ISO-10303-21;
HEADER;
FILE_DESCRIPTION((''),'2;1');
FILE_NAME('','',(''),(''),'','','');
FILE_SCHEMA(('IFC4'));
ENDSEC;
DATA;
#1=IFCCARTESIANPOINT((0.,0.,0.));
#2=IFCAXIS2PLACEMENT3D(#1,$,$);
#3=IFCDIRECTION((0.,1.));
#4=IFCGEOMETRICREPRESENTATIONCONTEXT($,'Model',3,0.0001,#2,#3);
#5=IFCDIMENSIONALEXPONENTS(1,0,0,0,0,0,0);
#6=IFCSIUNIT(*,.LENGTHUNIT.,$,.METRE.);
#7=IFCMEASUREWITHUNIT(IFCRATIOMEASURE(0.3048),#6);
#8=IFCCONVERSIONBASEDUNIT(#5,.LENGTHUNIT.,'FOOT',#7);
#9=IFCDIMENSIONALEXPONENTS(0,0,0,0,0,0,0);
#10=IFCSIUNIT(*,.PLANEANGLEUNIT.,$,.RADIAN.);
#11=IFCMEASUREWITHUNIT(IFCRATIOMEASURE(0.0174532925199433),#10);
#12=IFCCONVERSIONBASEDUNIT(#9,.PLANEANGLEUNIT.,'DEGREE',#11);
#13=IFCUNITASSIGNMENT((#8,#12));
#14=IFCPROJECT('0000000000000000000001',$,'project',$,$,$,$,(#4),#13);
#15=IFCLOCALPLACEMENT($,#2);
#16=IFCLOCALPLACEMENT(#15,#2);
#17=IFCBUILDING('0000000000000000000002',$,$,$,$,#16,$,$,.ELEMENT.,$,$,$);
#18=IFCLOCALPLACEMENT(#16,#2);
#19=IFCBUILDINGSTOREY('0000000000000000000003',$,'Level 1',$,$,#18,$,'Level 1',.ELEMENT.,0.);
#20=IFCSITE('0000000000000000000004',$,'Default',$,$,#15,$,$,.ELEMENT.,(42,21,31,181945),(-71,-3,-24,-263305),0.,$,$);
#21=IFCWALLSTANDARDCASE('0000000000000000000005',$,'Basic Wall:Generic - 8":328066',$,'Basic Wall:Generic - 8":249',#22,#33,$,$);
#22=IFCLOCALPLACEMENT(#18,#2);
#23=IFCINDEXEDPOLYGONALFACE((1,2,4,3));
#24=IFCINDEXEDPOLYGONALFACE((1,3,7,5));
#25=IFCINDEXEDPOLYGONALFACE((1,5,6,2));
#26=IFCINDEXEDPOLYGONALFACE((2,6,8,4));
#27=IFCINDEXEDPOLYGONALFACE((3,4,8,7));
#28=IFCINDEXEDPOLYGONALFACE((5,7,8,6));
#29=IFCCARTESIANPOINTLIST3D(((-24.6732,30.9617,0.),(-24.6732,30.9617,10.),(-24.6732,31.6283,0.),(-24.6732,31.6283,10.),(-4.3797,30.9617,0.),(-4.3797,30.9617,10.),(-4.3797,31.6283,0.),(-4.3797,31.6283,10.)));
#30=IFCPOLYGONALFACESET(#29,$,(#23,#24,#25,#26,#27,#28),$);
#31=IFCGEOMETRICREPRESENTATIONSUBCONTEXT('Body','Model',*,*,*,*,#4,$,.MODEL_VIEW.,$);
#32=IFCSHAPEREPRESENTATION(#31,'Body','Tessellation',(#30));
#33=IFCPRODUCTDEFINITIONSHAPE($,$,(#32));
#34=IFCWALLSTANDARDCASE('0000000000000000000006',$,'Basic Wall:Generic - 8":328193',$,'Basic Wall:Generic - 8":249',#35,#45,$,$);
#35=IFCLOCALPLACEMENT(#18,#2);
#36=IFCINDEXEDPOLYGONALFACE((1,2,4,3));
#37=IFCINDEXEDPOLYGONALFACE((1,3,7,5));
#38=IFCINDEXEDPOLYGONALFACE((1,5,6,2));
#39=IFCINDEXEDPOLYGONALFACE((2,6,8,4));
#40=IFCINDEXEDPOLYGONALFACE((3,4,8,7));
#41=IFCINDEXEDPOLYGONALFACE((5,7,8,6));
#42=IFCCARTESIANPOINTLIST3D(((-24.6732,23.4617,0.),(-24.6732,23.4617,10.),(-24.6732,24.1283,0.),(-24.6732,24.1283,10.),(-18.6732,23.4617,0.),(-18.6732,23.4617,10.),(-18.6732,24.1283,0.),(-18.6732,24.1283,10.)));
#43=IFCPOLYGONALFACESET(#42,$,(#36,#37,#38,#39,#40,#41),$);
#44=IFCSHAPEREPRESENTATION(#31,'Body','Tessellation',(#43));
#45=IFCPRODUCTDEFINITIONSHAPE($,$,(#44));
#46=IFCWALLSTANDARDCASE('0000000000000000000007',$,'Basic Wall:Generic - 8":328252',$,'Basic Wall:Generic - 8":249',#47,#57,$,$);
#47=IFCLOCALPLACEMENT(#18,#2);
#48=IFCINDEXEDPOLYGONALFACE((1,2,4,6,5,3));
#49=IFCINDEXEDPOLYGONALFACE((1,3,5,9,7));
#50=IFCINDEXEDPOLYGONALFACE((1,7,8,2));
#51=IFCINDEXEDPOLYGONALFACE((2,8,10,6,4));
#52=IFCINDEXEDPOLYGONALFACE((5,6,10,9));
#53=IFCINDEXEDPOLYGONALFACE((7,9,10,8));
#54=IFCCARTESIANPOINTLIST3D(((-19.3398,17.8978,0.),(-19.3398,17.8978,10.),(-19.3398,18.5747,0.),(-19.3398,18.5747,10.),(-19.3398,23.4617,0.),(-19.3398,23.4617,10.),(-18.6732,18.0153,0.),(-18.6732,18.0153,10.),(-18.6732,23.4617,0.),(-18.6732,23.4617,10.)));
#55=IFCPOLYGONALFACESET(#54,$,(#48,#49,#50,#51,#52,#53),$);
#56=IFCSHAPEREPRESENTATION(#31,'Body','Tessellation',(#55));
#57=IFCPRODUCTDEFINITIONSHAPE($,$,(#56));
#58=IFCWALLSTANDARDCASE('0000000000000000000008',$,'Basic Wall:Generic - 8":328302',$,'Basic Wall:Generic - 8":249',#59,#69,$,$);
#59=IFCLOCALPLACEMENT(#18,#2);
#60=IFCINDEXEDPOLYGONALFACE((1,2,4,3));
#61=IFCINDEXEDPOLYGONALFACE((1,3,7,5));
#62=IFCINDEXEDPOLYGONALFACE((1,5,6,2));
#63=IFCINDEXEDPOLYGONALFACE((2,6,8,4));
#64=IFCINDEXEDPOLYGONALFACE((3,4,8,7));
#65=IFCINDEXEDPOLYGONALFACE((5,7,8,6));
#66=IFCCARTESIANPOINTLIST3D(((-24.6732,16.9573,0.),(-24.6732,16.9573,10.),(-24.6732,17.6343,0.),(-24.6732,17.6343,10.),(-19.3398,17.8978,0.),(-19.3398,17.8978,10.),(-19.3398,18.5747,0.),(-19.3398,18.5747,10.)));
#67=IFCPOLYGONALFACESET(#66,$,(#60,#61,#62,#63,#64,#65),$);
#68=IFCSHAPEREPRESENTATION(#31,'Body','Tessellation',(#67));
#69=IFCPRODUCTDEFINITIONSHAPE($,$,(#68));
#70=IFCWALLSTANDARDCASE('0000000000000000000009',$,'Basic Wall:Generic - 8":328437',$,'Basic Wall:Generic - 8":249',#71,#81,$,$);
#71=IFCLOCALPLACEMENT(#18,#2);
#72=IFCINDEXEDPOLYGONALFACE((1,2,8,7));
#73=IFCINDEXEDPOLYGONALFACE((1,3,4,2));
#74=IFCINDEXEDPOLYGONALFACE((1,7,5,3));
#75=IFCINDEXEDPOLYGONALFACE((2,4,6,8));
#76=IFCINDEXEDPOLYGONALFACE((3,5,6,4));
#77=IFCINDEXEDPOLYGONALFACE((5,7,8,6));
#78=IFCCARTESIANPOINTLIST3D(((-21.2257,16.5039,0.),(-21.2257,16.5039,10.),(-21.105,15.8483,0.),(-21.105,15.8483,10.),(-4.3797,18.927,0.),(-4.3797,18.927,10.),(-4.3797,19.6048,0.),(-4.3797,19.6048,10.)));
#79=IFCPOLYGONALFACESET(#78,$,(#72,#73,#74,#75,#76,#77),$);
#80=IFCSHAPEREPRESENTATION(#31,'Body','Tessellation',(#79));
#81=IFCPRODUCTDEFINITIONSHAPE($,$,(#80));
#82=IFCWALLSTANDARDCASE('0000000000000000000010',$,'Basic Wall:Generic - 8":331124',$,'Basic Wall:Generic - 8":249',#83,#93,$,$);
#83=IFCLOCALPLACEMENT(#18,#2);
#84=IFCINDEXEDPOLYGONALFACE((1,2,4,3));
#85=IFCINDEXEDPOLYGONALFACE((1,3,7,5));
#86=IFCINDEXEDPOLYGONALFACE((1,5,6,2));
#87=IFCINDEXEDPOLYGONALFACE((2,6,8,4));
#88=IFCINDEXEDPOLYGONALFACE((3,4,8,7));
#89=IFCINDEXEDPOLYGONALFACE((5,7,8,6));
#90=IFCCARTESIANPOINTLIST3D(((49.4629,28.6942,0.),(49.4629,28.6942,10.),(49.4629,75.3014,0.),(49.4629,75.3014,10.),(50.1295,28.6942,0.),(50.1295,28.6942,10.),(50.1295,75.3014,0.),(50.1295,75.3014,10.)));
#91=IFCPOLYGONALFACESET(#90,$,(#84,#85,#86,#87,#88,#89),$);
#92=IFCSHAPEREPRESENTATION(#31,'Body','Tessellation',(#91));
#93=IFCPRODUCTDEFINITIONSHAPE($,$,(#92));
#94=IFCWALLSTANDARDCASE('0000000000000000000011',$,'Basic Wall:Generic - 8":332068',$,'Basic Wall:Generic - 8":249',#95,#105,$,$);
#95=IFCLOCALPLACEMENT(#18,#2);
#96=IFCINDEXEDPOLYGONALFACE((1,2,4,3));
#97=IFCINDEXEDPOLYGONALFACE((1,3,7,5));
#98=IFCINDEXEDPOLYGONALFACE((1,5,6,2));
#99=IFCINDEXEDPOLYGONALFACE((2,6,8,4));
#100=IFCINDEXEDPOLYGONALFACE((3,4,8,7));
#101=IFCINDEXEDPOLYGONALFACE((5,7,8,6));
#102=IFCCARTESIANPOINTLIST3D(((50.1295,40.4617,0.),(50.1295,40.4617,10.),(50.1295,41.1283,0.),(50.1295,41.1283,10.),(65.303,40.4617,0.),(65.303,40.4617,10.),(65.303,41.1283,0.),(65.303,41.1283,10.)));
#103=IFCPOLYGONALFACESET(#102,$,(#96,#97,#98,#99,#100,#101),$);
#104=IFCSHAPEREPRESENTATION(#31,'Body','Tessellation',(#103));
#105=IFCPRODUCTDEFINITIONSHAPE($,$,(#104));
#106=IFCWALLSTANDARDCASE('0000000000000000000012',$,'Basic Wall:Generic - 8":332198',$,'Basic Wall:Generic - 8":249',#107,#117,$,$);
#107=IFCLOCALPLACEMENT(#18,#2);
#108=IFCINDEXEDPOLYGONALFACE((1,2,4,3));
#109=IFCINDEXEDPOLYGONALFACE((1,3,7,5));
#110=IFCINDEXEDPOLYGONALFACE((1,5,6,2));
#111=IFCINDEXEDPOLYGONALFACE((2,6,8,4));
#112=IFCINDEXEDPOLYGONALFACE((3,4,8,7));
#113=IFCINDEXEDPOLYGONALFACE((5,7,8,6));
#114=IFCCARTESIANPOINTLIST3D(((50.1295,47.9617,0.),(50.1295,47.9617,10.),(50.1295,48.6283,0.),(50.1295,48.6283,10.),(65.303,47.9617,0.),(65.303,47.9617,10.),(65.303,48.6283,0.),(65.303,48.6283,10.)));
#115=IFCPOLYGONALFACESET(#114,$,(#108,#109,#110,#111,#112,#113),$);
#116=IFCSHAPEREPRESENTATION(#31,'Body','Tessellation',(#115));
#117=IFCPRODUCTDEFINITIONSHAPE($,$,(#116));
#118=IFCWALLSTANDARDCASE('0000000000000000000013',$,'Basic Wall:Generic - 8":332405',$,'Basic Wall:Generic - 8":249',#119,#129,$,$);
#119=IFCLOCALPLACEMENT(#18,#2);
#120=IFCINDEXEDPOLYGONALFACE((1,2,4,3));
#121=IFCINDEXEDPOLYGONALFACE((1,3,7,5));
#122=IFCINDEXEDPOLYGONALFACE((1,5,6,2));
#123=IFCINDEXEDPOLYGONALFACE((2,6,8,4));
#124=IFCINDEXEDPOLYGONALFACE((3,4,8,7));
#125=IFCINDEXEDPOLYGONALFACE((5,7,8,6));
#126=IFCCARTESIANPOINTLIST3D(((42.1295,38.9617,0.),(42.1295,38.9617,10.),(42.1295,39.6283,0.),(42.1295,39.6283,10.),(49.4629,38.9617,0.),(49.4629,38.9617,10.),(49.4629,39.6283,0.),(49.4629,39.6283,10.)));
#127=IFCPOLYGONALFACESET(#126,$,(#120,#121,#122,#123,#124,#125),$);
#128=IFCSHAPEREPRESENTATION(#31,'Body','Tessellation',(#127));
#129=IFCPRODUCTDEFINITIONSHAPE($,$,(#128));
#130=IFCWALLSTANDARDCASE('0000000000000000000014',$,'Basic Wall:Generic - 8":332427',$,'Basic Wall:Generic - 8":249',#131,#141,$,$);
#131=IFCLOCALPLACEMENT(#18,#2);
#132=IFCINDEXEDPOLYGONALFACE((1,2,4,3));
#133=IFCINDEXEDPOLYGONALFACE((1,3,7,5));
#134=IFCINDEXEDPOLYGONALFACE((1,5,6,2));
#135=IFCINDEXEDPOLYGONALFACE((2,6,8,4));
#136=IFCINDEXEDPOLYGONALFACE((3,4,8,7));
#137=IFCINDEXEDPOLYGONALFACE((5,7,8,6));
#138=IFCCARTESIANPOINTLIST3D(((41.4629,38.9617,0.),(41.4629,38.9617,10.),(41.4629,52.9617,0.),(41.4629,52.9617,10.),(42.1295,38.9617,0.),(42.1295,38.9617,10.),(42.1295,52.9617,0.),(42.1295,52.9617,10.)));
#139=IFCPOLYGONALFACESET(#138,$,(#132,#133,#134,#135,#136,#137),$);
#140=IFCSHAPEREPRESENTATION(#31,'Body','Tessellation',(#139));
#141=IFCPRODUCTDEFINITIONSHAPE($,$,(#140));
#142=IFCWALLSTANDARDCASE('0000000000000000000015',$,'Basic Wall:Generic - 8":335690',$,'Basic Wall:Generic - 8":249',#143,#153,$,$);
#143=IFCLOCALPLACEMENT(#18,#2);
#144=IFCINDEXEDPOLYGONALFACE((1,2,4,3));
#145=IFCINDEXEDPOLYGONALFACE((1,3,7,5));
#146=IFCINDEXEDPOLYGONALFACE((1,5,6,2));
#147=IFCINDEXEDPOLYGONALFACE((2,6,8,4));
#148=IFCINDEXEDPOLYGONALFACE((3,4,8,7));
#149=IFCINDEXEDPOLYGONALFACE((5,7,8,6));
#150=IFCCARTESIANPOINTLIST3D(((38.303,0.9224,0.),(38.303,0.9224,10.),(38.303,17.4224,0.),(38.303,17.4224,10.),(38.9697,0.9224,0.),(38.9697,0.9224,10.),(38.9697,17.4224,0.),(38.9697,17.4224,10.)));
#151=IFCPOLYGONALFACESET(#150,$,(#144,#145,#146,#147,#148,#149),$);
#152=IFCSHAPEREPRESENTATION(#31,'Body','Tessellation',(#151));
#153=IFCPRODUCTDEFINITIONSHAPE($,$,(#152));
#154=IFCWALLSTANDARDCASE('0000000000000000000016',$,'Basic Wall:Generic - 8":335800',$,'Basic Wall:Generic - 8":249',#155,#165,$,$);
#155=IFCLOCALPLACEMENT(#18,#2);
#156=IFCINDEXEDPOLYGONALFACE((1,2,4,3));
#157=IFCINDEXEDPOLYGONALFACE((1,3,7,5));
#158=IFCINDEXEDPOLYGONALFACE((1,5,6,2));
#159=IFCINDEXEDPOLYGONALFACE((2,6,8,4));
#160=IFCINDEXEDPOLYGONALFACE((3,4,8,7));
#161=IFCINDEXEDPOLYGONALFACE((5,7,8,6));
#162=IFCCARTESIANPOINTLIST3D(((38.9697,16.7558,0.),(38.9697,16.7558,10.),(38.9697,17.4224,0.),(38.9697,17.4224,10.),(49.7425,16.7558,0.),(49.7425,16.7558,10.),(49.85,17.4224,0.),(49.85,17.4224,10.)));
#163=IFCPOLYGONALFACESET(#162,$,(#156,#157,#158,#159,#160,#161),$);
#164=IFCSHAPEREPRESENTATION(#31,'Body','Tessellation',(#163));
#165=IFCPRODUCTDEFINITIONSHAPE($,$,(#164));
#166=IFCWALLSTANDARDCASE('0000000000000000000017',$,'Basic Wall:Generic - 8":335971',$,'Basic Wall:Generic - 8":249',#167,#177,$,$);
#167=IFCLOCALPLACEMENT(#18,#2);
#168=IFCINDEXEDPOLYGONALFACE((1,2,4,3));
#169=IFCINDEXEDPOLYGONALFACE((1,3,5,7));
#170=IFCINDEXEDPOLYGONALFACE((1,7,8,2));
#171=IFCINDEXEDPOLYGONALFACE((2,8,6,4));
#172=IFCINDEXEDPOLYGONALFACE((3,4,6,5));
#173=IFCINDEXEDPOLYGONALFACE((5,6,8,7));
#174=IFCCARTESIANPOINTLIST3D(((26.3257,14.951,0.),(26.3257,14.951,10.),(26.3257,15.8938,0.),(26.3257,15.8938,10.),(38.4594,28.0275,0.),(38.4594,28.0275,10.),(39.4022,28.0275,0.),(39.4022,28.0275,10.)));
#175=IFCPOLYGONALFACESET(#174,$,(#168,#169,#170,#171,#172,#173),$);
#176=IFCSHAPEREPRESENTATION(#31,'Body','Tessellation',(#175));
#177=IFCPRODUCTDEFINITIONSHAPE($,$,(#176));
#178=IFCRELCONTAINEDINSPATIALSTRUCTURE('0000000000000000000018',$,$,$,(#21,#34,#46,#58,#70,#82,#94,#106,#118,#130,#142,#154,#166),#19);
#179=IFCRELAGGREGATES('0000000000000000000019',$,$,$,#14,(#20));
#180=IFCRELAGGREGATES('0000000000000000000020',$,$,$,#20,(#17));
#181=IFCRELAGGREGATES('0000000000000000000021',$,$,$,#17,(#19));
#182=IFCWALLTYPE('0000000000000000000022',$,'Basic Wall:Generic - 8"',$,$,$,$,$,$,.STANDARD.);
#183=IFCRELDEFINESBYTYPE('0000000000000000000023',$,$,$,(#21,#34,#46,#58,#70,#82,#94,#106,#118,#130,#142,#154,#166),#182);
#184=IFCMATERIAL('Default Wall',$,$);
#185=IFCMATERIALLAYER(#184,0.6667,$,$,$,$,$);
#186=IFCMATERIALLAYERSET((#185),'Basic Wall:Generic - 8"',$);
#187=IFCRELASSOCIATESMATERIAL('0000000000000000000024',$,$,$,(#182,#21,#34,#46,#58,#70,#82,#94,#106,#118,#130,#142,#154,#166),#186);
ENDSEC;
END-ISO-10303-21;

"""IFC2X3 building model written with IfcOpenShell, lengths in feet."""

from ifc_helpers import new_model, entity, si_unit, converted_unit, direction, frame, frame_2d, origin, place, context, subcontext, project, spatial, polyline, rectangle, outline, extrude, material, layer, layer_set, layer_usage, type_object, element, save


model = new_model("IFC2X3")

# Units and contexts
model_context = context("Model", 3, precision=0.0001, world=origin(), true_north=direction((0.0, 1.0)))
body_context = subcontext(model_context, "Body", "Model", "MODEL_VIEW")
ifc_project = project(units=[converted_unit("LENGTHUNIT", "FOOT", entity("IfcRatioMeasure", 0.3048), si_unit("LENGTHUNIT", "METRE"), dimensions=[1, 0, 0, 0, 0, 0, 0]), converted_unit("PLANEANGLEUNIT", "DEGREE", entity("IfcRatioMeasure", 0.0174532925199433), si_unit("PLANEANGLEUNIT", "RADIAN"), dimensions=[0, 0, 0, 0, 0, 0, 0])], contexts=[model_context])

# Site, building, storey
site_placement = place(None, origin())
site = spatial("IfcSite", under=ifc_project, at=site_placement, Name="Default", CompositionType="ELEMENT", RefLatitude=(42, 21, 31, 181945), RefLongitude=(-71, -3, -24, -263305), RefElevation=0.0)
building_placement = place(site_placement, origin())
building = spatial("IfcBuilding", under=site, at=building_placement, CompositionType="ELEMENT")
storey_placement = place(building_placement, origin())
storey = spatial("IfcBuildingStorey", under=building, at=storey_placement, Name="Level 1", LongName="Level 1", CompositionType="ELEMENT", Elevation=0.0)

# Shared definitions
ifc_material_1 = material(Name="Default Wall")
ifc_layer = layer(ifc_material_1, 0.6667)
ifc_layer_set = layer_set([ifc_layer], Name="Basic Wall:Generic - 8\"")
wall_type = type_object("IfcWallType", Name="Basic Wall:Generic - 8\"", PredefinedType="STANDARD", material=ifc_layer_set)

# Walls
ifc_layer_usage_1 = layer_usage(ifc_layer_set, "AXIS2", "NEGATIVE", 0.3333)
wall_1_placement = place(storey_placement, frame((-4.3797, 31.295, 0.0), z_axis=(0.0, 0.0, 1.0), x_axis=(-1.0, 0.0, 0.0)))
element("IfcWallStandardCase", 1, at=wall_1_placement, inside=storey, type_object=wall_type, material=ifc_layer_usage_1, Name="Basic Wall:Generic - 8\":328066", ObjectType="Basic Wall:Generic - 8\":249", context=body_context, shape_type="SweptSolid", body=[
    extrude(rectangle(XDim=20.2935, YDim=0.6667, at=frame_2d((10.1468, 0.0), x_axis=(-1.0, 0.0))), origin(), (0.0, 0.0, 1.0), 10.0),
])
ifc_layer_usage_2 = layer_usage(ifc_layer_set, "AXIS2", "NEGATIVE", 0.3333)
wall_2_placement = place(storey_placement, frame((-24.6732, 23.795, 0.0)))
element("IfcWallStandardCase", 2, at=wall_2_placement, inside=storey, type_object=wall_type, material=ifc_layer_usage_2, Name="Basic Wall:Generic - 8\":328193", ObjectType="Basic Wall:Generic - 8\":249", context=body_context, shape_type="SweptSolid", body=[
    extrude(rectangle(XDim=6.0, YDim=0.6667, at=frame_2d((3.0, 0.0), x_axis=(-1.0, 0.0))), origin(), (0.0, 0.0, 1.0), 10.0),
])
ifc_layer_usage_3 = layer_usage(ifc_layer_set, "AXIS2", "NEGATIVE", 0.3333)
wall_3_placement = place(storey_placement, frame((-19.0065, 23.4617, 0.0), z_axis=(0.0, 0.0, 1.0), x_axis=(0.0, -1.0, 0.0)))
element("IfcWallStandardCase", 3, at=wall_3_placement, inside=storey, type_object=wall_type, material=ifc_layer_usage_3, Name="Basic Wall:Generic - 8\":328252", ObjectType="Basic Wall:Generic - 8\":249", context=body_context, shape_type="SweptSolid", body=[
    extrude(outline(polyline([(5.5639, -0.3333), (5.4464, 0.3333), (0.0, 0.3333), (0.0, -0.3333), (4.887, -0.3333), (5.5639, -0.3333)])), origin(), (0.0, 0.0, 1.0), 10.0),
])
ifc_layer_usage_4 = layer_usage(ifc_layer_set, "AXIS2", "POSITIVE", -0.3333)
wall_4_placement = place(storey_placement, frame((-19.282, 18.2464, 0.0), z_axis=(0.0, 0.0, 1.0), x_axis=(-0.984808, -0.173648, 0.0)))
element("IfcWallStandardCase", 4, at=wall_4_placement, inside=storey, type_object=wall_type, material=ifc_layer_usage_4, Name="Basic Wall:Generic - 8\":328302", ObjectType="Basic Wall:Generic - 8\":249", context=body_context, shape_type="SweptSolid", body=[
    extrude(outline(polyline([(5.4156, -0.3333), (5.5332, 0.3333), (0.1176, 0.3333), (0.0, -0.3333), (5.4156, -0.3333)])), origin(), (0.0, 0.0, 1.0), 10.0),
])
ifc_layer_usage_5 = layer_usage(ifc_layer_set, "AXIS2", "NEGATIVE", 0.3333)
wall_5_placement = place(storey_placement, frame((-21.1653, 16.1761, 0.0), z_axis=(0.0, 0.0, 1.0), x_axis=(0.983477, 0.181032, 0.0)))
element("IfcWallStandardCase", 5, at=wall_5_placement, inside=storey, type_object=wall_type, material=ifc_layer_usage_5, Name="Basic Wall:Generic - 8\":328437", ObjectType="Basic Wall:Generic - 8\":249", context=body_context, shape_type="SweptSolid", body=[
    extrude(outline(polyline([(17.0063, -0.3333), (17.129, 0.3333), (0.0, 0.3333), (0.0, -0.3333), (17.0063, -0.3333)])), origin(), (0.0, 0.0, 1.0), 10.0),
])
ifc_layer_usage_6 = layer_usage(ifc_layer_set, "AXIS2", "NEGATIVE", 0.3333)
wall_6_placement = place(storey_placement, frame((49.7962, 28.6942, 0.0), z_axis=(0.0, 0.0, 1.0), x_axis=(0.0, 1.0, 0.0)))
element("IfcWallStandardCase", 6, at=wall_6_placement, inside=storey, type_object=wall_type, material=ifc_layer_usage_6, Name="Basic Wall:Generic - 8\":331124", ObjectType="Basic Wall:Generic - 8\":249", context=body_context, shape_type="SweptSolid", body=[
    extrude(rectangle(XDim=46.6072, YDim=0.6667, at=frame_2d((23.3036, 0.0), x_axis=(-1.0, 0.0))), origin(), (0.0, 0.0, 1.0), 10.0),
])
ifc_layer_usage_7 = layer_usage(ifc_layer_set, "AXIS2", "NEGATIVE", 0.3333)
wall_7_placement = place(storey_placement, frame((50.1295, 40.795, 0.0)))
element("IfcWallStandardCase", 7, at=wall_7_placement, inside=storey, type_object=wall_type, material=ifc_layer_usage_7, Name="Basic Wall:Generic - 8\":332068", ObjectType="Basic Wall:Generic - 8\":249", context=body_context, shape_type="SweptSolid", body=[
    extrude(rectangle(XDim=15.1735, YDim=0.6667, at=frame_2d((7.5867, 0.0), x_axis=(-1.0, 0.0))), origin(), (0.0, 0.0, 1.0), 10.0),
])
ifc_layer_usage_8 = layer_usage(ifc_layer_set, "AXIS2", "NEGATIVE", 0.3333)
wall_8_placement = place(storey_placement, frame((50.1295, 48.295, 0.0)))
element("IfcWallStandardCase", 8, at=wall_8_placement, inside=storey, type_object=wall_type, material=ifc_layer_usage_8, Name="Basic Wall:Generic - 8\":332198", ObjectType="Basic Wall:Generic - 8\":249", context=body_context, shape_type="SweptSolid", body=[
    extrude(rectangle(XDim=15.1735, YDim=0.6667, at=frame_2d((7.5867, 0.0), x_axis=(-1.0, 0.0))), origin(), (0.0, 0.0, 1.0), 10.0),
])
ifc_layer_usage_9 = layer_usage(ifc_layer_set, "AXIS2", "NEGATIVE", 0.3333)
wall_9_placement = place(storey_placement, frame((49.4629, 39.295, 0.0), z_axis=(0.0, 0.0, 1.0), x_axis=(-1.0, 0.0, 0.0)))
element("IfcWallStandardCase", 9, at=wall_9_placement, inside=storey, type_object=wall_type, material=ifc_layer_usage_9, Name="Basic Wall:Generic - 8\":332405", ObjectType="Basic Wall:Generic - 8\":249", context=body_context, shape_type="SweptSolid", body=[
    extrude(rectangle(XDim=7.3333, YDim=0.6667, at=frame_2d((3.6667, 0.0), x_axis=(-1.0, 0.0))), origin(), (0.0, 0.0, 1.0), 10.0),
])
ifc_layer_usage_10 = layer_usage(ifc_layer_set, "AXIS2", "NEGATIVE", 0.3333)
wall_10_placement = place(storey_placement, frame((41.7962, 38.9617, 0.0), z_axis=(0.0, 0.0, 1.0), x_axis=(0.0, 1.0, 0.0)))
element("IfcWallStandardCase", 10, at=wall_10_placement, inside=storey, type_object=wall_type, material=ifc_layer_usage_10, Name="Basic Wall:Generic - 8\":332427", ObjectType="Basic Wall:Generic - 8\":249", context=body_context, shape_type="SweptSolid", body=[
    extrude(rectangle(XDim=14.0, YDim=0.6667, at=frame_2d((7.0, 0.0), x_axis=(-1.0, 0.0))), origin(), (0.0, 0.0, 1.0), 10.0),
])
ifc_layer_usage_11 = layer_usage(ifc_layer_set, "AXIS2", "NEGATIVE", 0.3333)
wall_11_placement = place(storey_placement, frame((38.6363, 0.9224, 0.0), z_axis=(0.0, 0.0, 1.0), x_axis=(0.0, 1.0, 0.0)))
element("IfcWallStandardCase", 11, at=wall_11_placement, inside=storey, type_object=wall_type, material=ifc_layer_usage_11, Name="Basic Wall:Generic - 8\":335690", ObjectType="Basic Wall:Generic - 8\":249", context=body_context, shape_type="SweptSolid", body=[
    extrude(rectangle(XDim=16.5, YDim=0.6667, at=frame_2d((8.25, 0.0), x_axis=(-1.0, 0.0))), origin(), (0.0, 0.0, 1.0), 10.0),
])
ifc_layer_usage_12 = layer_usage(ifc_layer_set, "AXIS2", "NEGATIVE", 0.3333)
wall_12_placement = place(storey_placement, frame((38.9697, 17.0891, 0.0)))
element("IfcWallStandardCase", 12, at=wall_12_placement, inside=storey, type_object=wall_type, material=ifc_layer_usage_12, Name="Basic Wall:Generic - 8\":335800", ObjectType="Basic Wall:Generic - 8\":249", context=body_context, shape_type="SweptSolid", body=[
    extrude(outline(polyline([(10.7728, -0.3333), (10.8804, 0.3333), (0.0, 0.3333), (0.0, -0.3333), (10.7728, -0.3333)])), origin(), (0.0, 0.0, 1.0), 10.0),
])
ifc_layer_usage_13 = layer_usage(ifc_layer_set, "AXIS2", "NEGATIVE", 0.3333)
wall_13_placement = place(storey_placement, frame((26.09, 15.1867, 0.0), z_axis=(0.0, 0.0, 1.0), x_axis=(0.707107, 0.707107, 0.0)))
element("IfcWallStandardCase", 13, at=wall_13_placement, inside=storey, type_object=wall_type, material=ifc_layer_usage_13, Name="Basic Wall:Generic - 8\":335971", ObjectType="Basic Wall:Generic - 8\":249", context=body_context, shape_type="SweptSolid", body=[
    extrude(outline(polyline([(18.493, -0.3333), (17.8263, 0.3333), (0.6667, 0.3333), (0.0, -0.3333), (18.493, -0.3333)])), origin(), (0.0, 0.0, 1.0), 10.0),
])

save(model, "model.ifc")
